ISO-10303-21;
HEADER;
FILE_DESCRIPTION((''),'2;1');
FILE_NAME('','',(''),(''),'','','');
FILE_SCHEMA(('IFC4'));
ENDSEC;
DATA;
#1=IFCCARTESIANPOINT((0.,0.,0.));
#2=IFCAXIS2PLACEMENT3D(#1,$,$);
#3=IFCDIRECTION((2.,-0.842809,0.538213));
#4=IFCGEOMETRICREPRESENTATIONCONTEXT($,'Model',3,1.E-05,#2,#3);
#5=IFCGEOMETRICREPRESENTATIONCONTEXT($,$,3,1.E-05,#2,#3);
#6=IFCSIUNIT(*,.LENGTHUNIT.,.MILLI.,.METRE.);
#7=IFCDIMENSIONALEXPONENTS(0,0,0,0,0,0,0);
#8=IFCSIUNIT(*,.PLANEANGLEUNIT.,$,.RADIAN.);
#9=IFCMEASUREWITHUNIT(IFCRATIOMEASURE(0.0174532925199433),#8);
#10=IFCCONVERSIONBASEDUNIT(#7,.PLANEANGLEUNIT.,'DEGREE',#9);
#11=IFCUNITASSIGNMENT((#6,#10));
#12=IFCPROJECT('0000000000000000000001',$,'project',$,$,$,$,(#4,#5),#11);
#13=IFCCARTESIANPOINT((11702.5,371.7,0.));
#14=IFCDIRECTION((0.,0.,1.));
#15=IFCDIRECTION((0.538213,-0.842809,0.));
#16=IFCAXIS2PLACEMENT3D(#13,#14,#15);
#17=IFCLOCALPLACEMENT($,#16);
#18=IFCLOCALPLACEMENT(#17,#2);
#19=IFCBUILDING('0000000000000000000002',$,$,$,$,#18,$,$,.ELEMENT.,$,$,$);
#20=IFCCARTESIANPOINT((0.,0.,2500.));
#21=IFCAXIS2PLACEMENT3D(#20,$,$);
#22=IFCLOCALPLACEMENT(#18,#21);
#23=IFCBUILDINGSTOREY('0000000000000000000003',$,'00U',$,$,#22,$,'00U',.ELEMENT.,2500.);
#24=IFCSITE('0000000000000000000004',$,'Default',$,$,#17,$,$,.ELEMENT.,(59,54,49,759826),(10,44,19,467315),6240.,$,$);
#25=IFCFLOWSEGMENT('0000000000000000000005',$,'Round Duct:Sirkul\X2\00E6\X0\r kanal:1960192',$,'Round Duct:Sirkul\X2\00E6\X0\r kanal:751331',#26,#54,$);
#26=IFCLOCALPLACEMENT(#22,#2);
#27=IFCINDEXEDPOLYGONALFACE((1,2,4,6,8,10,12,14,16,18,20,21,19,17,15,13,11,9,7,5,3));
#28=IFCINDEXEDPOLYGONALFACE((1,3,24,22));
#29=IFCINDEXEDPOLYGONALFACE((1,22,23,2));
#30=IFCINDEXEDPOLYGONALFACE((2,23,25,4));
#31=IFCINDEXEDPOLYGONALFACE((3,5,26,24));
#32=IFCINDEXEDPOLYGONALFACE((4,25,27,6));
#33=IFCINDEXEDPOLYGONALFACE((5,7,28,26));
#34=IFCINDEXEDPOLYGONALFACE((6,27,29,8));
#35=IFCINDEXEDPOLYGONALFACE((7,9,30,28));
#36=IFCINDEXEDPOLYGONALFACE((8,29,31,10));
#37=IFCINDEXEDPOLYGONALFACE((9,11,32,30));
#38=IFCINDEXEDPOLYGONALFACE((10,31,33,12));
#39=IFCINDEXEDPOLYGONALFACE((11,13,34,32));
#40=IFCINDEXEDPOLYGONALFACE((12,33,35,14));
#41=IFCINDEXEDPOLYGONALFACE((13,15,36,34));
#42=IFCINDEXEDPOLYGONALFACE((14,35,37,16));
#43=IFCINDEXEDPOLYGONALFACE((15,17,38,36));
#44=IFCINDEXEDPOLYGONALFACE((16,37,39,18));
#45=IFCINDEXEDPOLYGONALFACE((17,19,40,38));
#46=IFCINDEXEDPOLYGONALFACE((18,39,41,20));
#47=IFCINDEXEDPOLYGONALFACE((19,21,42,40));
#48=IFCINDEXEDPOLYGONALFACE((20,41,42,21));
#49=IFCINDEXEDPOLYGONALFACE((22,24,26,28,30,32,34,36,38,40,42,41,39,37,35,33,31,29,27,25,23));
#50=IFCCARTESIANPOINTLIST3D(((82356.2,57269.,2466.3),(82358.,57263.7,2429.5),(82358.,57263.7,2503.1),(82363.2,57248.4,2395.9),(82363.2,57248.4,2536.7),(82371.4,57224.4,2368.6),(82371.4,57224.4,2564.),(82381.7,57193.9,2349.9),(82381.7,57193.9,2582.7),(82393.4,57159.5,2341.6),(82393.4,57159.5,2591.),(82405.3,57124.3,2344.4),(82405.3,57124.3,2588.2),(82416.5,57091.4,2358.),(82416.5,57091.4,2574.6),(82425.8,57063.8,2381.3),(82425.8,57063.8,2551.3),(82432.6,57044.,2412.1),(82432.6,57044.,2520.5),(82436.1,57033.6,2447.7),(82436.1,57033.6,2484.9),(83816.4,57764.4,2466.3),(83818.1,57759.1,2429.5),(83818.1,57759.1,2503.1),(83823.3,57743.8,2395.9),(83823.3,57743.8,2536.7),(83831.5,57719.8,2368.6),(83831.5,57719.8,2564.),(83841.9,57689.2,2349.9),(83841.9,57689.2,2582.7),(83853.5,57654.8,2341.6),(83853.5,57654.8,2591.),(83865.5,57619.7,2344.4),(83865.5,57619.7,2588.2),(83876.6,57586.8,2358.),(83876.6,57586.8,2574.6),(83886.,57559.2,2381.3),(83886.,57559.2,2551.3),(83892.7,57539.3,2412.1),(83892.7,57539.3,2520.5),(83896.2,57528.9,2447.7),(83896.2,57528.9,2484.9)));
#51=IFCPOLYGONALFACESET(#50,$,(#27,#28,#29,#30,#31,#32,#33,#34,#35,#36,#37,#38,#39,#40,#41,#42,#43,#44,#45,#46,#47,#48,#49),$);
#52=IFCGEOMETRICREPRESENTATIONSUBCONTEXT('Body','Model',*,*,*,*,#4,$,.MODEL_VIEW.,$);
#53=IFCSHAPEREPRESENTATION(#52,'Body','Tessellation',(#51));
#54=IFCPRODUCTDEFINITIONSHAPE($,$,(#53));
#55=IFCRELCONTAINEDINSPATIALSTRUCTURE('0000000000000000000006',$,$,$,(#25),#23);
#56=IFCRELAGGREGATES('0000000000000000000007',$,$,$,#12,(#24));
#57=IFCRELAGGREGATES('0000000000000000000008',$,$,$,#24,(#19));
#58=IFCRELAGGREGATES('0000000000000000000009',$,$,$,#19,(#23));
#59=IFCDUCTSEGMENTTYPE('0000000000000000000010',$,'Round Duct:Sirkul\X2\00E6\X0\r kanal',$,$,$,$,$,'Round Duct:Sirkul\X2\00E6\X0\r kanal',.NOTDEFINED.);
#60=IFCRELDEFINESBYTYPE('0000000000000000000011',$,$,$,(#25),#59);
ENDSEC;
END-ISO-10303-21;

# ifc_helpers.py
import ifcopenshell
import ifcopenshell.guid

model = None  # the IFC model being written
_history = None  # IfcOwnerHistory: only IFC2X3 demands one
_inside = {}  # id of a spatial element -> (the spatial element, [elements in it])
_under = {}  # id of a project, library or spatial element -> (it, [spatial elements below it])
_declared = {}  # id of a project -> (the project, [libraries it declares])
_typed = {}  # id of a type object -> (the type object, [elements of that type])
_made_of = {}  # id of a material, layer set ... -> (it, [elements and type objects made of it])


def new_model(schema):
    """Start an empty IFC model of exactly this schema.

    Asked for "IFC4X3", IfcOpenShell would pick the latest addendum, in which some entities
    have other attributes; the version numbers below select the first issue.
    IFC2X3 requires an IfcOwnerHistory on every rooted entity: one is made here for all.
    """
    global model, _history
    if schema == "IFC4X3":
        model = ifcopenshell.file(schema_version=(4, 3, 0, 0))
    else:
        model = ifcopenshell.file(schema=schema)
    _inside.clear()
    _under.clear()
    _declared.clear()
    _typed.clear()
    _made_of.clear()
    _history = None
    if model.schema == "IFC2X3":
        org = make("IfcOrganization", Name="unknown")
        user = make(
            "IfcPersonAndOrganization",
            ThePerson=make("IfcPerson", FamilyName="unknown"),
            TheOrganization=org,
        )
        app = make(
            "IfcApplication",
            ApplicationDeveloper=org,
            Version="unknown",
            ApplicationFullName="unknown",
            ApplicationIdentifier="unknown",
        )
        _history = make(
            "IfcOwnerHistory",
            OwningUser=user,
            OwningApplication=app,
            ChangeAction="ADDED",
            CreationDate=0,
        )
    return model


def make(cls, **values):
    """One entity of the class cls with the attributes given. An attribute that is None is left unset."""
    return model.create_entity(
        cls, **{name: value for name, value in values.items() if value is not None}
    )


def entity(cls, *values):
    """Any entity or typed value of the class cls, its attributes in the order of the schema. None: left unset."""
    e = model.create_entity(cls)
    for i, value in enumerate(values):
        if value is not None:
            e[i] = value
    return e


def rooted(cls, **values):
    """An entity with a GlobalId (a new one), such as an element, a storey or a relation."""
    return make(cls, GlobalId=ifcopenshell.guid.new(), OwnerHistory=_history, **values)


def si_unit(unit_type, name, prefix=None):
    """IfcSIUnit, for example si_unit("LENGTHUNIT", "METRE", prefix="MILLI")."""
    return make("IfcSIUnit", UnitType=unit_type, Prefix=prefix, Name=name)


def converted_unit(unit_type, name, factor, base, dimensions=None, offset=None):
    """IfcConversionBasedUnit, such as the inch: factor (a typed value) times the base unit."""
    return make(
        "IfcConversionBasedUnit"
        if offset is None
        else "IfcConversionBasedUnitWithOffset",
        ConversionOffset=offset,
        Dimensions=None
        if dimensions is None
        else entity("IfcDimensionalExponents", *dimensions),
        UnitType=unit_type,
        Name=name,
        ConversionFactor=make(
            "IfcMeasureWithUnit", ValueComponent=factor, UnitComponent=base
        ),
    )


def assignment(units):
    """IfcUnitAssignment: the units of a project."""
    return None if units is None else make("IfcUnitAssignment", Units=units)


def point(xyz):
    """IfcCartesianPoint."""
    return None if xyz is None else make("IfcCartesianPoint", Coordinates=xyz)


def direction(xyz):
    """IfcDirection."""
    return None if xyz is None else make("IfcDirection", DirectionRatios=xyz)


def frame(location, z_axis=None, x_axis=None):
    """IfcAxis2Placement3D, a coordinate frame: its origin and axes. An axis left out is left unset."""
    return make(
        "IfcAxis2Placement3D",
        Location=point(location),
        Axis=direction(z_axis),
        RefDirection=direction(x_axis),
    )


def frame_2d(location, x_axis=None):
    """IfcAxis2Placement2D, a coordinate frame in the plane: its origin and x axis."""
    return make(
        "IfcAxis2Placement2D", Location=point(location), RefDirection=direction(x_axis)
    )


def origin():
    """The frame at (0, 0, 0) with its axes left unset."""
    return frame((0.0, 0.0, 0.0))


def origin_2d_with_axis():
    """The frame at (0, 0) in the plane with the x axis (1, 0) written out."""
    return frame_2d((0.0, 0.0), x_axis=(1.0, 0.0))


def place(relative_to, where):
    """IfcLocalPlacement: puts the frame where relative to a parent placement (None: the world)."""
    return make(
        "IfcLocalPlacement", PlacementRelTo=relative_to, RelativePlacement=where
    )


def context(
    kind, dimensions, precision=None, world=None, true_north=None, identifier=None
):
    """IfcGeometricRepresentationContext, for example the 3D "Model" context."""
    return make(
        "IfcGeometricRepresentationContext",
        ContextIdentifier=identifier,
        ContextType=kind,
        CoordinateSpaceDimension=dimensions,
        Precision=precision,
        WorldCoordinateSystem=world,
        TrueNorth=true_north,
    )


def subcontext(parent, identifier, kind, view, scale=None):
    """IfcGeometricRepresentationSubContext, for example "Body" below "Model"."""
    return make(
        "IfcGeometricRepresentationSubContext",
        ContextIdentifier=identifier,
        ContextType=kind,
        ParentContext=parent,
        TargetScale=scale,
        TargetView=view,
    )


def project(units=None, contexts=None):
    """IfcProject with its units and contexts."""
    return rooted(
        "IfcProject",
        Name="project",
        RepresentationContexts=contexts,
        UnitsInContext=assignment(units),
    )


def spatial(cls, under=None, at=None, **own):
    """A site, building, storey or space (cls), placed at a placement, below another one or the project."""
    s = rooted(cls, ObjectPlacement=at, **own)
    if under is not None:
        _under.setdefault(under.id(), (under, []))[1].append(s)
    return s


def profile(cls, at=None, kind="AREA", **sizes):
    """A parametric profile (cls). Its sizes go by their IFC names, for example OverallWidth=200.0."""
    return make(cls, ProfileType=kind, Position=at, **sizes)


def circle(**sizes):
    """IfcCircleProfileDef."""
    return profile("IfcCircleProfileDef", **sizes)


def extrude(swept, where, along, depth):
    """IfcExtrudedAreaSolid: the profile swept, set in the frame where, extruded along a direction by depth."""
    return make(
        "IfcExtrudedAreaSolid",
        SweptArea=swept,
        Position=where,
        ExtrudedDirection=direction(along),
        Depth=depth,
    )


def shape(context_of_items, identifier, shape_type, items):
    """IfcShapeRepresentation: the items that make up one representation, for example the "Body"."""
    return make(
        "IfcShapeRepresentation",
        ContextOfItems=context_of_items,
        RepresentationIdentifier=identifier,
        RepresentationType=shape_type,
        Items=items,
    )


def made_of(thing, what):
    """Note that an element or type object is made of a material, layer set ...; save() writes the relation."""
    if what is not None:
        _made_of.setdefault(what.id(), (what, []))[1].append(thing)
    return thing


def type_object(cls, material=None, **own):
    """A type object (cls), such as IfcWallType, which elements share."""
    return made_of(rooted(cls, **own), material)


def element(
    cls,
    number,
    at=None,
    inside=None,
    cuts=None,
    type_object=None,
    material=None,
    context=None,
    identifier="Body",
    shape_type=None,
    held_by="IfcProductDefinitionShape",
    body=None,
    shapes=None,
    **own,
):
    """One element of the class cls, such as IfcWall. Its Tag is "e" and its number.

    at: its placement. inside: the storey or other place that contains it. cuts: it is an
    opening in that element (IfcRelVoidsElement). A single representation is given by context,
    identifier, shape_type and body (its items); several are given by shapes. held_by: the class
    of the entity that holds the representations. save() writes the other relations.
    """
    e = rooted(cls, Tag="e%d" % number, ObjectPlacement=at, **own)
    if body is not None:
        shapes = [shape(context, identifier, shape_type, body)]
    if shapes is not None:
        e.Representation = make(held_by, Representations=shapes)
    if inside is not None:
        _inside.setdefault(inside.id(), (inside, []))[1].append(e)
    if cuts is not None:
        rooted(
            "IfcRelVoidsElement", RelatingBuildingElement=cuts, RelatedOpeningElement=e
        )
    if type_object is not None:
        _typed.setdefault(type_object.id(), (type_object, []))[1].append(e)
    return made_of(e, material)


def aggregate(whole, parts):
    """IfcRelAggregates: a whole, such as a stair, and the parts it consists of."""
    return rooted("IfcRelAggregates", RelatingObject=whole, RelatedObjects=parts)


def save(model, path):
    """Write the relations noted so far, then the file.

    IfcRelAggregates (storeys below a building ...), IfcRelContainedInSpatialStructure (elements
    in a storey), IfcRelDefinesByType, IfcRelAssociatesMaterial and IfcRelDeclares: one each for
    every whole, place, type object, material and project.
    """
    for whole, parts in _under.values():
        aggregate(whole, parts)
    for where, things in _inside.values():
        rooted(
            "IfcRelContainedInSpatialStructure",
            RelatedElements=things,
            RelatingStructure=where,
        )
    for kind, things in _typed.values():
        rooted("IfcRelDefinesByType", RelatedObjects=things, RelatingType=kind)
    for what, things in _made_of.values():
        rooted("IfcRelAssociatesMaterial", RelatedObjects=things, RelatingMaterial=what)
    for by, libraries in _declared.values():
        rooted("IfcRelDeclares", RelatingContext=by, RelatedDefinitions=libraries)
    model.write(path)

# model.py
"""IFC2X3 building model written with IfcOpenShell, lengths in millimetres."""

from ifc_helpers import new_model, entity, si_unit, converted_unit, direction, frame, origin, origin_2d_with_axis, place, context, subcontext, project, spatial, circle, extrude, type_object, element, save


model = new_model("IFC2X3")

# Units and contexts
model_context = context("Model", 3, precision=1e-05, world=origin(), true_north=direction((2.0, -0.842809, 0.538213)))
context_of_model = context(None, 3, precision=1e-05, world=origin(), true_north=direction((2.0, -0.842809, 0.538213)))
body_context = subcontext(model_context, "Body", "Model", "MODEL_VIEW")
ifc_project = project(units=[si_unit("LENGTHUNIT", "METRE", prefix="MILLI"), converted_unit("PLANEANGLEUNIT", "DEGREE", entity("IfcRatioMeasure", 0.0174532925199433), si_unit("PLANEANGLEUNIT", "RADIAN"), dimensions=[0, 0, 0, 0, 0, 0, 0])], contexts=[model_context, context_of_model])

# Site, building, storey
site_placement = place(None, frame((11702.5, 371.7, 0.0), z_axis=(0.0, 0.0, 1.0), x_axis=(0.538213, -0.842809, 0.0)))
site = spatial("IfcSite", under=ifc_project, at=site_placement, Name="Default", CompositionType="ELEMENT", RefLatitude=(59, 54, 49, 759826), RefLongitude=(10, 44, 19, 467315), RefElevation=6240.0)
building_placement = place(site_placement, origin())
building = spatial("IfcBuilding", under=site, at=building_placement, CompositionType="ELEMENT")
storey_placement = place(building_placement, frame((0.0, 0.0, 2500.0)))
storey = spatial("IfcBuildingStorey", under=building, at=storey_placement, Name="00U", LongName="00U", CompositionType="ELEMENT", Elevation=2500.0)

# Flow segment
duct_segment_type_1 = type_object("IfcDuctSegmentType", Name="Round Duct:Sirkulær kanal", ElementType="Round Duct:Sirkulær kanal", PredefinedType="NOTDEFINED")
flow_segment_1_placement = place(storey_placement, origin())
element("IfcFlowSegment", 1, at=flow_segment_1_placement, inside=storey, type_object=duct_segment_type_1, Name="Round Duct:Sirkulær kanal:1960192", ObjectType="Round Duct:Sirkulær kanal:751331", context=body_context, shape_type="SweptSolid", body=[
    extrude(circle(Radius=125.0, at=origin_2d_with_axis()), frame((82396.4, 57150.6, 2466.3), z_axis=(0.946982, 0.321288, 0.0), x_axis=(-0.321288, 0.946982, 0.0)), (0.0, 0.0, 1.0), 1541.9),
])

save(model, "model.ifc")
